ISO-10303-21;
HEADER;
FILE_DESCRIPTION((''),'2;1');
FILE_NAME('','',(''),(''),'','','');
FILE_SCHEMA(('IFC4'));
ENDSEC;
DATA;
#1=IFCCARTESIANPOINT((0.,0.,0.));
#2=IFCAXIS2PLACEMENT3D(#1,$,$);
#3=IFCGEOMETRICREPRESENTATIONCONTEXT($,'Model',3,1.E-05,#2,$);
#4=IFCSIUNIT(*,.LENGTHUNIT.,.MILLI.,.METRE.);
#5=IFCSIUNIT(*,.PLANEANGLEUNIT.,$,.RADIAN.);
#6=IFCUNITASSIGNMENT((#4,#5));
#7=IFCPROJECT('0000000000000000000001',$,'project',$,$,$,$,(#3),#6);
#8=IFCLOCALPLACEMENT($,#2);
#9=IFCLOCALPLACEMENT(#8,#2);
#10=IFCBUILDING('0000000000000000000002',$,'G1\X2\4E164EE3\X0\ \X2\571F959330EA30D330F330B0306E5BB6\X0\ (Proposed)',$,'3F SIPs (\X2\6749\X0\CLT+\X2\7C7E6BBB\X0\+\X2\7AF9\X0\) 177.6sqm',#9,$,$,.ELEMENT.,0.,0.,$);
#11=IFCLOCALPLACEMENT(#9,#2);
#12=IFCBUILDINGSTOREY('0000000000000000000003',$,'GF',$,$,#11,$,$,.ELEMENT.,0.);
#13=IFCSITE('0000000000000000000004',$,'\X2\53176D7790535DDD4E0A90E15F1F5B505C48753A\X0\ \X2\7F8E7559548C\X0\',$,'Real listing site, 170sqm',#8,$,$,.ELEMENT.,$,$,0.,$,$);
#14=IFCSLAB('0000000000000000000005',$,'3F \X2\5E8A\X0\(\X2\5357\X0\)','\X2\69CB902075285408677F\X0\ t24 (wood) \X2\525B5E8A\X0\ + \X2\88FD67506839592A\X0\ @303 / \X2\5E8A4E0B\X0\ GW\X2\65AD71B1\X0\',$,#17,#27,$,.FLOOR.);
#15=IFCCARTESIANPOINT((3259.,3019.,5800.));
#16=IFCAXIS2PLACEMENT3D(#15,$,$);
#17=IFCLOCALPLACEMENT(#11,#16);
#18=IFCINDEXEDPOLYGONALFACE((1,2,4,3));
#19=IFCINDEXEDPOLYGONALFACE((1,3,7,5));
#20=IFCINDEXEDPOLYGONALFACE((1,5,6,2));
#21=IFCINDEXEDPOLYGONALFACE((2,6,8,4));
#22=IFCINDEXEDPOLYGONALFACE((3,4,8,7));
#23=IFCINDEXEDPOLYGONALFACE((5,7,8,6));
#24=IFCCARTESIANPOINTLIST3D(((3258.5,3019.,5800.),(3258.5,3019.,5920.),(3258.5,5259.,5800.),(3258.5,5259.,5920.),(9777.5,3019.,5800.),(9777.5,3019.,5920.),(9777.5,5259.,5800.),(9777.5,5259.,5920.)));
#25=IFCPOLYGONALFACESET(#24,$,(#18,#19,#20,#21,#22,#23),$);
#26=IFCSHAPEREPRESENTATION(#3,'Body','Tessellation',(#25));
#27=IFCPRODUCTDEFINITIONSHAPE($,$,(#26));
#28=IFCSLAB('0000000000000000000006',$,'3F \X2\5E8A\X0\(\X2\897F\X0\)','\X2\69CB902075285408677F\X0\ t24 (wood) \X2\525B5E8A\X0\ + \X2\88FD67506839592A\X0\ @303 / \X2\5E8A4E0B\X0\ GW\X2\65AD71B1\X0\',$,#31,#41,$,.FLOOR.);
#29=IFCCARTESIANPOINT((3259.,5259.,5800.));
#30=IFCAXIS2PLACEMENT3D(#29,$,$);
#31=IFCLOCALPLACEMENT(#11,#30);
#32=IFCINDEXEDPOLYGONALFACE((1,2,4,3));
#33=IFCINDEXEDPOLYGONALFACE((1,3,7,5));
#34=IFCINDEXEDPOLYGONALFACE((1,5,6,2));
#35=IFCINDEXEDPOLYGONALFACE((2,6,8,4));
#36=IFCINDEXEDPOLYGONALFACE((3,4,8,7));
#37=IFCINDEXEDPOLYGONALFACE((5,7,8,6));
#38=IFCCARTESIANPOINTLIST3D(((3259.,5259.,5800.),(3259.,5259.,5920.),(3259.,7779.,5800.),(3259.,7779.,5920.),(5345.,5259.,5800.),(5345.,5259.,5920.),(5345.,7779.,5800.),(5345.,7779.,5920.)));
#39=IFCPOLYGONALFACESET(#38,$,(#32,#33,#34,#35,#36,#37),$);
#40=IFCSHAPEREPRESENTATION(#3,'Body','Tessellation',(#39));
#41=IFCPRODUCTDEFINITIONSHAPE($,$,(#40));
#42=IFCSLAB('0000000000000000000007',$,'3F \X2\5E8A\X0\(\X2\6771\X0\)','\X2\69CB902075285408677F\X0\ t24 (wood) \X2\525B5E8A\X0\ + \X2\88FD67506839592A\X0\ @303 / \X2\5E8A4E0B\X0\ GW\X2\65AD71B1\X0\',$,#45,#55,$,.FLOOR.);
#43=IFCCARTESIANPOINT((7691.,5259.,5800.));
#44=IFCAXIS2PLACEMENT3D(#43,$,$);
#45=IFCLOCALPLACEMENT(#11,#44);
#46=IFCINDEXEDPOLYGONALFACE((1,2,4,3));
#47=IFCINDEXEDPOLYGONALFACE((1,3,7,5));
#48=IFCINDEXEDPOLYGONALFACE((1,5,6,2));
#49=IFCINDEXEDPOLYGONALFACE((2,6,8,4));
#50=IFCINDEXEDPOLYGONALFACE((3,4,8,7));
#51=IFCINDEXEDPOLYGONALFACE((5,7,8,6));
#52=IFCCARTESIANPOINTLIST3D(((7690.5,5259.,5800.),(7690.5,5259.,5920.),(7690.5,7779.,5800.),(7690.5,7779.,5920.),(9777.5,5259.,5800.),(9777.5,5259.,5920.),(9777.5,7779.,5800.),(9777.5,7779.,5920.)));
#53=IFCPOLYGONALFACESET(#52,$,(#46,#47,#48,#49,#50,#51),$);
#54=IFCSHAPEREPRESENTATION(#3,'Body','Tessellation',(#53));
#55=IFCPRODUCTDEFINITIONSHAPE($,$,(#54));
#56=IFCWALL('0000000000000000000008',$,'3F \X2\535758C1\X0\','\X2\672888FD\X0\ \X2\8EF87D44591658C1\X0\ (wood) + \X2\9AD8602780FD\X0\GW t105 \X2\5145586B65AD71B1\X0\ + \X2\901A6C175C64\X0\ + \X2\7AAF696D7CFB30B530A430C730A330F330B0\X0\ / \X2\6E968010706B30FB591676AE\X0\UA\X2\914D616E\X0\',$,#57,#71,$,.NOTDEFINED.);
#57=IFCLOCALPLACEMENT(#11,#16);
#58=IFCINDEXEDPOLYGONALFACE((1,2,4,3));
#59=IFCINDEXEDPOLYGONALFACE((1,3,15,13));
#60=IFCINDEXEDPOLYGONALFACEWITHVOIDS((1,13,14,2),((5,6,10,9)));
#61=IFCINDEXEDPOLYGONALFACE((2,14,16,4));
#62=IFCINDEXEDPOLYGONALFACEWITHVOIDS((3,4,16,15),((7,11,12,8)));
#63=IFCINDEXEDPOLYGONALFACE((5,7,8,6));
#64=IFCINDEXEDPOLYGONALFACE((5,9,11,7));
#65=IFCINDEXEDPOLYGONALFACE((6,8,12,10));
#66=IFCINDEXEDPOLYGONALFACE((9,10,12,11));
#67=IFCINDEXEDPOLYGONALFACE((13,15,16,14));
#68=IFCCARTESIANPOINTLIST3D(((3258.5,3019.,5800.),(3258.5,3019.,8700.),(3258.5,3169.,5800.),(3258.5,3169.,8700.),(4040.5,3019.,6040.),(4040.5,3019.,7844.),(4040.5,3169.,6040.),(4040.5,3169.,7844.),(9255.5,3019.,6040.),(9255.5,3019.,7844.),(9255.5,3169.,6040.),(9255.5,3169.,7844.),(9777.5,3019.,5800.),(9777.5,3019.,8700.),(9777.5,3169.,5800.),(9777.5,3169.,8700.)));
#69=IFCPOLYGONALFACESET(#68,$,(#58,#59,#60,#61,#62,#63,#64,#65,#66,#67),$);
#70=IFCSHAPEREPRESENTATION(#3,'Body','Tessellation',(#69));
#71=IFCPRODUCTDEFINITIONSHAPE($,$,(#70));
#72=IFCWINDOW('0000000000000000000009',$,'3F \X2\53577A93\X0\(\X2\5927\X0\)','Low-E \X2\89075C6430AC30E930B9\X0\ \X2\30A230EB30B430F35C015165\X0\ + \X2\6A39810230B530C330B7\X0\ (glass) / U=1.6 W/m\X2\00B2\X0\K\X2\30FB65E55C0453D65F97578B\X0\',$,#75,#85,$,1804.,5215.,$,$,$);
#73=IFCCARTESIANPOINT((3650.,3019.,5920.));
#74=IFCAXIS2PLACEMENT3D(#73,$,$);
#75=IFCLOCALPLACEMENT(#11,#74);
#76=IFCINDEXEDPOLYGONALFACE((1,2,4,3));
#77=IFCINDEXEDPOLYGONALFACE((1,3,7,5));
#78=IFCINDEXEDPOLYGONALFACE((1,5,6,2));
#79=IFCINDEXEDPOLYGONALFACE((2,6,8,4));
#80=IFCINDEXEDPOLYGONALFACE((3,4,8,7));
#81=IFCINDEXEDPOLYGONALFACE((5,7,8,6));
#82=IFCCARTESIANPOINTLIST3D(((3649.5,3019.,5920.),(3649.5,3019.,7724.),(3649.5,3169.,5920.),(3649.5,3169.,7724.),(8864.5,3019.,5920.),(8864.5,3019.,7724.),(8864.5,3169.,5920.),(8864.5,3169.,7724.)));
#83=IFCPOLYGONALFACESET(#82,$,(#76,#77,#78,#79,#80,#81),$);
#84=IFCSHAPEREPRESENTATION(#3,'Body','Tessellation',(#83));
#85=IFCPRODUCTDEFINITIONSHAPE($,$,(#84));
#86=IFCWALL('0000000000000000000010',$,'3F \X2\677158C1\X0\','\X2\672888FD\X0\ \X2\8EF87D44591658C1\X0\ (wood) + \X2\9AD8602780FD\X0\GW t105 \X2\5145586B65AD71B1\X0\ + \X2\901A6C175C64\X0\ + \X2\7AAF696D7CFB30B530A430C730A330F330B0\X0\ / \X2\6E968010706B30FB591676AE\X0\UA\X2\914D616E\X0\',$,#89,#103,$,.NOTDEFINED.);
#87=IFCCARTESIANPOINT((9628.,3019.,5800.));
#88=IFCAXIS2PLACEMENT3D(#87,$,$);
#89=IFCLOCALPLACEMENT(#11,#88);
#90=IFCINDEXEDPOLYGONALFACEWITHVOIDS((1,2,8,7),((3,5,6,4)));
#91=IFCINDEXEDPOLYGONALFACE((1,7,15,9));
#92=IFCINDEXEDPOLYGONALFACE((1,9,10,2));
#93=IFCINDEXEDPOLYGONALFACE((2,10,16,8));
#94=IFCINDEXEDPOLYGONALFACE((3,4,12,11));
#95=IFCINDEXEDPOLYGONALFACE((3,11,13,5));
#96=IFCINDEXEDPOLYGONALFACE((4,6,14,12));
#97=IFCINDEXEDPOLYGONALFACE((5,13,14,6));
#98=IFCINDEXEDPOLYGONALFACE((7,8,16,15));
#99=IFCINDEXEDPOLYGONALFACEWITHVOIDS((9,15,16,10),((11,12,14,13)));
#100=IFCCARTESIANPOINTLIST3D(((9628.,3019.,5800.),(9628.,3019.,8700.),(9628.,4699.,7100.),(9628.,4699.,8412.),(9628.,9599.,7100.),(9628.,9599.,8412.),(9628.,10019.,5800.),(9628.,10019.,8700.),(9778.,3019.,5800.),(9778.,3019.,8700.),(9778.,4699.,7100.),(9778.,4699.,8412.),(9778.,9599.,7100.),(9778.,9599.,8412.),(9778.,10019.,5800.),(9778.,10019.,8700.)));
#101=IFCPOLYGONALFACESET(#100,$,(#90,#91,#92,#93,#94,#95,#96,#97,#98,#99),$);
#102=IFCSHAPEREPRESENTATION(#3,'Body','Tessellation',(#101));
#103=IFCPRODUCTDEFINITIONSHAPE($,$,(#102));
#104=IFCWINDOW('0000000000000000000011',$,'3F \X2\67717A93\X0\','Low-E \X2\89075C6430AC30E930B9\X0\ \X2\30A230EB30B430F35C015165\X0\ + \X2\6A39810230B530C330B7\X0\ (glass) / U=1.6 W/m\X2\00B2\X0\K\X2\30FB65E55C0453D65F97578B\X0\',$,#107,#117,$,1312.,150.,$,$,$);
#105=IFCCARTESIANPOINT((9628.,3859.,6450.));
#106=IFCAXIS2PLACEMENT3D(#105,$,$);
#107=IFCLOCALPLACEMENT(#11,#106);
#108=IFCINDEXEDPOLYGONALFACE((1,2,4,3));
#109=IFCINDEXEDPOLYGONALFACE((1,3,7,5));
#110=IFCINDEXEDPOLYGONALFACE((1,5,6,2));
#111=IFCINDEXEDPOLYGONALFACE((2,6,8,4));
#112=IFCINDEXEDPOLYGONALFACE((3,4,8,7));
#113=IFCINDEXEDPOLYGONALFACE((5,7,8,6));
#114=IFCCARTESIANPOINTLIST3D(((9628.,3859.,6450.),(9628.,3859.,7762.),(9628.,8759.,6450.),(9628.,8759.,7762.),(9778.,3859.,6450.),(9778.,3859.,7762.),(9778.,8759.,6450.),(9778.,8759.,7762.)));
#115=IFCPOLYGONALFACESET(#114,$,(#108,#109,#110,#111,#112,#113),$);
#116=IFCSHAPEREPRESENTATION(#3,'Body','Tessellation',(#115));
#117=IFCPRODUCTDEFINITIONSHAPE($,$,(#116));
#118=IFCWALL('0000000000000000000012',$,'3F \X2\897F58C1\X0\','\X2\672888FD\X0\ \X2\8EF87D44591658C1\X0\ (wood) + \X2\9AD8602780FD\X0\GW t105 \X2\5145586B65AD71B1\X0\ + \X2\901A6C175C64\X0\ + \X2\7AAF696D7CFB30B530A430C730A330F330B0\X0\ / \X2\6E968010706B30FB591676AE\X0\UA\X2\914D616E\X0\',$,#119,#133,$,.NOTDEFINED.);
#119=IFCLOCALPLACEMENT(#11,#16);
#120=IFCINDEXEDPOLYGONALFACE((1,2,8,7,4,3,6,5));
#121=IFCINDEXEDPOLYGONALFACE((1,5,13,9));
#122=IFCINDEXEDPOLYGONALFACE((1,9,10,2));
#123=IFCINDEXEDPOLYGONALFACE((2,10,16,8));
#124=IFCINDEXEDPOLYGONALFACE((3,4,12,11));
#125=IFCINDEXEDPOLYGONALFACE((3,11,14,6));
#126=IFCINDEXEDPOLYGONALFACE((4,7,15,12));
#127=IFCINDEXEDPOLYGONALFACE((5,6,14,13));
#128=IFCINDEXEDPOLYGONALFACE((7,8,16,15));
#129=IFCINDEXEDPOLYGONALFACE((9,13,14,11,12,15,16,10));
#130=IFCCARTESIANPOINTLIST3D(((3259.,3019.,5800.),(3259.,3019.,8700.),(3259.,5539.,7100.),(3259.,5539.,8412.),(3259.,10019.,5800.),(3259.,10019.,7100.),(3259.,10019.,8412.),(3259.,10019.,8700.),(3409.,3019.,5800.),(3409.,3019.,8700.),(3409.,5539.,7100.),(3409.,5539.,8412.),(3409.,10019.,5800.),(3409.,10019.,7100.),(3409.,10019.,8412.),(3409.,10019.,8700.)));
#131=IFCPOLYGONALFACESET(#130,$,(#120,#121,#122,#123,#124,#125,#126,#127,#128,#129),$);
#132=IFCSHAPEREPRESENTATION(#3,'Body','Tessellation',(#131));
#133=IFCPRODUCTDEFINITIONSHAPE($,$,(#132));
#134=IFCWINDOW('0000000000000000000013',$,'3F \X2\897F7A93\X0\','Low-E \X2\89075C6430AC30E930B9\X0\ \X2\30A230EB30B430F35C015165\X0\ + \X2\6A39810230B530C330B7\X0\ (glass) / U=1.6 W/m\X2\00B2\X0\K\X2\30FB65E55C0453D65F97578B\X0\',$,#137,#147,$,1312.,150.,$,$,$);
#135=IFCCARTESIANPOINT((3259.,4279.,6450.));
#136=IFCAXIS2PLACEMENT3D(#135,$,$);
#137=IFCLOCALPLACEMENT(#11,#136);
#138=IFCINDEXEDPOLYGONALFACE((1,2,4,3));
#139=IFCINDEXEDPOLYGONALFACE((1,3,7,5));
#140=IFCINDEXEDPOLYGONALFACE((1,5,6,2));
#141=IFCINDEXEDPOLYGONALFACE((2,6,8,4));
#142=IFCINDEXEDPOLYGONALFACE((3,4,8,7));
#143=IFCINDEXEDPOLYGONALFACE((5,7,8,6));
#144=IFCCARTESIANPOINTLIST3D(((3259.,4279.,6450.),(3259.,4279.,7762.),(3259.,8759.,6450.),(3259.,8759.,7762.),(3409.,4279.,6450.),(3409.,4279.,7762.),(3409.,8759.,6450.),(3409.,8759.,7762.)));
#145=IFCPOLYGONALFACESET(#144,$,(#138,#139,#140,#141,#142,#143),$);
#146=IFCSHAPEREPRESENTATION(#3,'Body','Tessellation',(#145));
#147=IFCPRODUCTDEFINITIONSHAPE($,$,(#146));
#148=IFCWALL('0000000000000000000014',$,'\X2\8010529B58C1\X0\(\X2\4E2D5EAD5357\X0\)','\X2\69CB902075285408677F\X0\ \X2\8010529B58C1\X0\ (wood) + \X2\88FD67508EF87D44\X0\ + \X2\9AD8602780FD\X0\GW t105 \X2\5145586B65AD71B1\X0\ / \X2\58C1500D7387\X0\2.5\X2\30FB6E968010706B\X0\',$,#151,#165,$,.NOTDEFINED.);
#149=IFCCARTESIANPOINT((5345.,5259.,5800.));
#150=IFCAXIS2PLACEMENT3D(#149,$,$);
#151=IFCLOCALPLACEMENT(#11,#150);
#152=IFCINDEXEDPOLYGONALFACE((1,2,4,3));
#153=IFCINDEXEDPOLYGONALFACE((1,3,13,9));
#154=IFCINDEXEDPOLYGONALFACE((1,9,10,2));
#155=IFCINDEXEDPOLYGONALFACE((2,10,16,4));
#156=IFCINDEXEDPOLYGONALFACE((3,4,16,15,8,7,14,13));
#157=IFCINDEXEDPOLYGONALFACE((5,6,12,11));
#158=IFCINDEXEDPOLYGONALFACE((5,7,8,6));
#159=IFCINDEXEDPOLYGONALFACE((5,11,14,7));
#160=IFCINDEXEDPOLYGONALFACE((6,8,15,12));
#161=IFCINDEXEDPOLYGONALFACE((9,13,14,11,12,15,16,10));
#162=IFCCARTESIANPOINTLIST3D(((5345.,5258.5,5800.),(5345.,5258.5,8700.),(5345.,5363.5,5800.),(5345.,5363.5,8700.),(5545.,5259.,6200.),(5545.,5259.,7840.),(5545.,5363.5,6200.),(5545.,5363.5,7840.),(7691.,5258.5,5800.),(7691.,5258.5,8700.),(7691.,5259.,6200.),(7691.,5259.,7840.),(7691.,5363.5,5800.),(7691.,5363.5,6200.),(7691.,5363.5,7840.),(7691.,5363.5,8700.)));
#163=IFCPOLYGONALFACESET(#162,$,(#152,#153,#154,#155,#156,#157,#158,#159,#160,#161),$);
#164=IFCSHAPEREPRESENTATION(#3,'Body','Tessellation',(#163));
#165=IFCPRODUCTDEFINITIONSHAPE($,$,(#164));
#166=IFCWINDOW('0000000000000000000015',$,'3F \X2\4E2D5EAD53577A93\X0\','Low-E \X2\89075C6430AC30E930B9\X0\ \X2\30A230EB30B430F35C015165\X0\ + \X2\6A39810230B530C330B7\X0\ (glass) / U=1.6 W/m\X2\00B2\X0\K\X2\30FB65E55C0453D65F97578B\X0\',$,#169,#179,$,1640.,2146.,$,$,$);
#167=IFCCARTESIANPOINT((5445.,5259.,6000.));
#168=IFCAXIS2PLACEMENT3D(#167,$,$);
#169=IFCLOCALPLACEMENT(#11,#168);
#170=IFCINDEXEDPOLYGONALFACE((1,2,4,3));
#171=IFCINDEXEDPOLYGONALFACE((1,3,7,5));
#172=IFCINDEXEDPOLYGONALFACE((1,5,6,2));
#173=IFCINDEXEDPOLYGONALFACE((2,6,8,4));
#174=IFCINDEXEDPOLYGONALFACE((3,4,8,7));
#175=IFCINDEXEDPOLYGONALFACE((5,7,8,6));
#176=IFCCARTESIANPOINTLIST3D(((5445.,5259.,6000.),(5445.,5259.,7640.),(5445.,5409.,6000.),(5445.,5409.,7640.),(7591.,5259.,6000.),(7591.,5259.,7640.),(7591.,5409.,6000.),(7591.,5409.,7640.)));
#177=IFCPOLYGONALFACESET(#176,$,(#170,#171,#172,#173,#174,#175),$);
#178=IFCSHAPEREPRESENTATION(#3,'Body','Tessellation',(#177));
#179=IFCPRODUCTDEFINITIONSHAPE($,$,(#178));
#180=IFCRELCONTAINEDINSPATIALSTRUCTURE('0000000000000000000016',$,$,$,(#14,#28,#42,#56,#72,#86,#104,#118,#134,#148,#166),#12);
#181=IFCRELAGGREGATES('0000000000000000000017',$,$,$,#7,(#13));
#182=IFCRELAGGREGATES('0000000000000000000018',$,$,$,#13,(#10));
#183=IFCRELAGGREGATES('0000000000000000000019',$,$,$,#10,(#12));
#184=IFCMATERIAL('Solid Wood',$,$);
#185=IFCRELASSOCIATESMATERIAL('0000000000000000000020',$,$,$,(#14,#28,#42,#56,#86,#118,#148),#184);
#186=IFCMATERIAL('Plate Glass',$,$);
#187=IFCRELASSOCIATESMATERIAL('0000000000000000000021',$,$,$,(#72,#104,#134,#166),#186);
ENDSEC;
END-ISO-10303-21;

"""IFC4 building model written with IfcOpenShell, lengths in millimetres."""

from ifc_helpers import new_model, si_unit, frame, frame_2d, origin, place, context, project, spatial, rectangle, extrude, material, element, fill, save


model = new_model("IFC4")

# Units and contexts
model_context = context("Model", 3, precision=1e-05, world=origin())
ifc_project = project(units=[si_unit("LENGTHUNIT", "METRE", prefix="MILLI"), si_unit("PLANEANGLEUNIT", "RADIAN")], contexts=[model_context])

# Site, building, storey
site_placement = place(None, origin())
site = spatial("IfcSite", under=ifc_project, at=site_placement, Name="北海道川上郡弟子屈町 美留和", ObjectType="Real listing site, 170sqm", CompositionType="ELEMENT", RefElevation=0.0)
building_placement = place(site_placement, origin())
building = spatial("IfcBuilding", under=site, at=building_placement, Name="G1世代 土間リビングの家 (Proposed)", ObjectType="3F SIPs (杉CLT+籾殻+竹) 177.6sqm", CompositionType="ELEMENT", ElevationOfRefHeight=0.0, ElevationOfTerrain=0.0)
storey_placement = place(building_placement, origin())
storey = spatial("IfcBuildingStorey", under=building, at=storey_placement, Name="GF", CompositionType="ELEMENT", Elevation=0.0)

# Slabs
ifc_material_1 = material(Name="Solid Wood")
slab_1_placement = place(storey_placement, frame((3259.0, 3019.0, 5800.0)))
element("IfcSlab", 1, at=slab_1_placement, inside=storey, material=ifc_material_1, Name="3F 床(南)", Description="構造用合板 t24 (wood) 剛床 + 製材根太 @303 / 床下 GW断熱", PredefinedType="FLOOR", context=model_context, shape_type="SweptSolid", body=[
    extrude(rectangle(XDim=6519.0, YDim=2240.0, at=frame_2d((3259.0, 1120.0))), frame((3259.0, 3019.0, 5800.0)), (0.0, 0.0, 1.0), 120.0),
])
slab_2_placement = place(storey_placement, frame((3259.0, 5259.0, 5800.0)))
element("IfcSlab", 2, at=slab_2_placement, inside=storey, material=ifc_material_1, Name="3F 床(西)", Description="構造用合板 t24 (wood) 剛床 + 製材根太 @303 / 床下 GW断熱", PredefinedType="FLOOR", context=model_context, shape_type="SweptSolid", body=[
    extrude(rectangle(XDim=2086.0, YDim=2520.0, at=frame_2d((1043.0, 1260.0))), frame((3259.0, 5259.0, 5800.0)), (0.0, 0.0, 1.0), 120.0),
])
slab_3_placement = place(storey_placement, frame((7691.0, 5259.0, 5800.0)))
element("IfcSlab", 3, at=slab_3_placement, inside=storey, material=ifc_material_1, Name="3F 床(東)", Description="構造用合板 t24 (wood) 剛床 + 製材根太 @303 / 床下 GW断熱", PredefinedType="FLOOR", context=model_context, shape_type="SweptSolid", body=[
    extrude(rectangle(XDim=2087.0, YDim=2520.0, at=frame_2d((1043.0, 1260.0))), frame((7691.0, 5259.0, 5800.0)), (0.0, 0.0, 1.0), 120.0),
])

# Walls, openings, windows
wall_1_placement = place(storey_placement, frame((3259.0, 3019.0, 5800.0)))
wall_1 = element("IfcWall", 4, at=wall_1_placement, inside=storey, material=ifc_material_1, Name="3F 南壁", Description="木製 軸組外壁 (wood) + 高性能GW t105 充填断熱 + 通気層 + 窯業系サイディング / 準耐火・外皮UA配慮", PredefinedType="NOTDEFINED", context=model_context, shape_type="SweptSolid", body=[
    extrude(rectangle(XDim=6519.0, YDim=150.0, at=frame_2d((3259.0, 75.0))), frame((3259.0, 3019.0, 5800.0)), (0.0, 0.0, 1.0), 2900.0),
])
opening_1_placement = place(storey_placement, frame((3650.0, 3019.0, 5920.0)))
opening_1 = element("IfcOpeningElement", 5, at=opening_1_placement, cuts=wall_1, PredefinedType="NOTDEFINED", context=model_context, shape_type="SweptSolid", body=[
    extrude(rectangle(XDim=5215.0, YDim=150.0, at=frame_2d((2607.0, 75.0))), frame((3650.0, 3019.0, 5920.0)), (0.0, 0.0, 1.0), 1804.0),
])
ifc_material_2 = material(Name="Plate Glass")
window_1_placement = place(storey_placement, frame((3650.0, 3019.0, 5920.0)))
window_1 = element("IfcWindow", 6, at=window_1_placement, inside=storey, material=ifc_material_2, Name="3F 南窓(大)", Description="Low-E 複層ガラス アルゴン封入 + 樹脂サッシ (glass) / U=1.6 W/m²K・日射取得型", OverallHeight=1804.0, OverallWidth=5215.0, context=model_context, shape_type="SweptSolid", body=[
    extrude(rectangle(XDim=5215.0, YDim=150.0, at=frame_2d((2607.0, 75.0))), frame((3650.0, 3019.0, 5920.0)), (0.0, 0.0, 1.0), 1804.0),
])
fill(opening_1, window_1)
wall_2_placement = place(storey_placement, frame((9628.0, 3019.0, 5800.0)))
wall_2 = element("IfcWall", 7, at=wall_2_placement, inside=storey, material=ifc_material_1, Name="3F 東壁", Description="木製 軸組外壁 (wood) + 高性能GW t105 充填断熱 + 通気層 + 窯業系サイディング / 準耐火・外皮UA配慮", PredefinedType="NOTDEFINED", context=model_context, shape_type="SweptSolid", body=[
    extrude(rectangle(XDim=150.0, YDim=7000.0, at=frame_2d((75.0, 3500.0))), frame((9628.0, 3019.0, 5800.0)), (0.0, 0.0, 1.0), 2900.0),
])
opening_2_placement = place(storey_placement, frame((9628.0, 3859.0, 6450.0)))
opening_2 = element("IfcOpeningElement", 8, at=opening_2_placement, cuts=wall_2, PredefinedType="NOTDEFINED", context=model_context, shape_type="SweptSolid", body=[
    extrude(rectangle(XDim=150.0, YDim=4900.0, at=frame_2d((75.0, 2450.0))), frame((9628.0, 3859.0, 6450.0)), (0.0, 0.0, 1.0), 1312.0),
])
window_2_placement = place(storey_placement, frame((9628.0, 3859.0, 6450.0)))
window_2 = element("IfcWindow", 9, at=window_2_placement, inside=storey, material=ifc_material_2, Name="3F 東窓", Description="Low-E 複層ガラス アルゴン封入 + 樹脂サッシ (glass) / U=1.6 W/m²K・日射取得型", OverallHeight=1312.0, OverallWidth=150.0, context=model_context, shape_type="SweptSolid", body=[
    extrude(rectangle(XDim=150.0, YDim=4900.0, at=frame_2d((75.0, 2450.0))), frame((9628.0, 3859.0, 6450.0)), (0.0, 0.0, 1.0), 1312.0),
])
fill(opening_2, window_2)
wall_3_placement = place(storey_placement, frame((3259.0, 3019.0, 5800.0)))
wall_3 = element("IfcWall", 10, at=wall_3_placement, inside=storey, material=ifc_material_1, Name="3F 西壁", Description="木製 軸組外壁 (wood) + 高性能GW t105 充填断熱 + 通気層 + 窯業系サイディング / 準耐火・外皮UA配慮", PredefinedType="NOTDEFINED", context=model_context, shape_type="SweptSolid", body=[
    extrude(rectangle(XDim=150.0, YDim=7000.0, at=frame_2d((75.0, 3500.0))), frame((3259.0, 3019.0, 5800.0)), (0.0, 0.0, 1.0), 2900.0),
])
opening_3_placement = place(storey_placement, frame((3259.0, 4279.0, 6450.0)))
opening_3 = element("IfcOpeningElement", 11, at=opening_3_placement, cuts=wall_3, PredefinedType="NOTDEFINED", context=model_context, shape_type="SweptSolid", body=[
    extrude(rectangle(XDim=150.0, YDim=4480.0, at=frame_2d((75.0, 2240.0))), frame((3259.0, 4279.0, 6450.0)), (0.0, 0.0, 1.0), 1312.0),
])
window_3_placement = place(storey_placement, frame((3259.0, 4279.0, 6450.0)))
window_3 = element("IfcWindow", 12, at=window_3_placement, inside=storey, material=ifc_material_2, Name="3F 西窓", Description="Low-E 複層ガラス アルゴン封入 + 樹脂サッシ (glass) / U=1.6 W/m²K・日射取得型", OverallHeight=1312.0, OverallWidth=150.0, context=model_context, shape_type="SweptSolid", body=[
    extrude(rectangle(XDim=150.0, YDim=4480.0, at=frame_2d((75.0, 2240.0))), frame((3259.0, 4279.0, 6450.0)), (0.0, 0.0, 1.0), 1312.0),
])
fill(opening_3, window_3)
wall_4_placement = place(storey_placement, frame((5345.0, 5259.0, 5800.0)))
wall_4 = element("IfcWall", 13, at=wall_4_placement, inside=storey, material=ifc_material_1, Name="耐力壁(中庭南)", Description="構造用合板 耐力壁 (wood) + 製材軸組 + 高性能GW t105 充填断熱 / 壁倍率2.5・準耐火", PredefinedType="NOTDEFINED", context=model_context, shape_type="SweptSolid", body=[
    extrude(rectangle(XDim=2346.0, YDim=105.0, at=frame_2d((1173.0, 52.0))), frame((5345.0, 5259.0, 5800.0)), (0.0, 0.0, 1.0), 2900.0),
])
opening_4_placement = place(storey_placement, frame((5445.0, 5259.0, 6000.0)))
opening_4 = element("IfcOpeningElement", 14, at=opening_4_placement, cuts=wall_4, PredefinedType="NOTDEFINED", context=model_context, shape_type="SweptSolid", body=[
    extrude(rectangle(XDim=2146.0, YDim=150.0, at=frame_2d((1073.0, 75.0))), frame((5445.0, 5259.0, 6000.0)), (0.0, 0.0, 1.0), 1640.0),
])
window_4_placement = place(storey_placement, frame((5445.0, 5259.0, 6000.0)))
window_4 = element("IfcWindow", 15, at=window_4_placement, inside=storey, material=ifc_material_2, Name="3F 中庭南窓", Description="Low-E 複層ガラス アルゴン封入 + 樹脂サッシ (glass) / U=1.6 W/m²K・日射取得型", OverallHeight=1640.0, OverallWidth=2146.0, context=model_context, shape_type="SweptSolid", body=[
    extrude(rectangle(XDim=2146.0, YDim=150.0, at=frame_2d((1073.0, 75.0))), frame((5445.0, 5259.0, 6000.0)), (0.0, 0.0, 1.0), 1640.0),
])
fill(opening_4, window_4)

save(model, "model.ifc")
